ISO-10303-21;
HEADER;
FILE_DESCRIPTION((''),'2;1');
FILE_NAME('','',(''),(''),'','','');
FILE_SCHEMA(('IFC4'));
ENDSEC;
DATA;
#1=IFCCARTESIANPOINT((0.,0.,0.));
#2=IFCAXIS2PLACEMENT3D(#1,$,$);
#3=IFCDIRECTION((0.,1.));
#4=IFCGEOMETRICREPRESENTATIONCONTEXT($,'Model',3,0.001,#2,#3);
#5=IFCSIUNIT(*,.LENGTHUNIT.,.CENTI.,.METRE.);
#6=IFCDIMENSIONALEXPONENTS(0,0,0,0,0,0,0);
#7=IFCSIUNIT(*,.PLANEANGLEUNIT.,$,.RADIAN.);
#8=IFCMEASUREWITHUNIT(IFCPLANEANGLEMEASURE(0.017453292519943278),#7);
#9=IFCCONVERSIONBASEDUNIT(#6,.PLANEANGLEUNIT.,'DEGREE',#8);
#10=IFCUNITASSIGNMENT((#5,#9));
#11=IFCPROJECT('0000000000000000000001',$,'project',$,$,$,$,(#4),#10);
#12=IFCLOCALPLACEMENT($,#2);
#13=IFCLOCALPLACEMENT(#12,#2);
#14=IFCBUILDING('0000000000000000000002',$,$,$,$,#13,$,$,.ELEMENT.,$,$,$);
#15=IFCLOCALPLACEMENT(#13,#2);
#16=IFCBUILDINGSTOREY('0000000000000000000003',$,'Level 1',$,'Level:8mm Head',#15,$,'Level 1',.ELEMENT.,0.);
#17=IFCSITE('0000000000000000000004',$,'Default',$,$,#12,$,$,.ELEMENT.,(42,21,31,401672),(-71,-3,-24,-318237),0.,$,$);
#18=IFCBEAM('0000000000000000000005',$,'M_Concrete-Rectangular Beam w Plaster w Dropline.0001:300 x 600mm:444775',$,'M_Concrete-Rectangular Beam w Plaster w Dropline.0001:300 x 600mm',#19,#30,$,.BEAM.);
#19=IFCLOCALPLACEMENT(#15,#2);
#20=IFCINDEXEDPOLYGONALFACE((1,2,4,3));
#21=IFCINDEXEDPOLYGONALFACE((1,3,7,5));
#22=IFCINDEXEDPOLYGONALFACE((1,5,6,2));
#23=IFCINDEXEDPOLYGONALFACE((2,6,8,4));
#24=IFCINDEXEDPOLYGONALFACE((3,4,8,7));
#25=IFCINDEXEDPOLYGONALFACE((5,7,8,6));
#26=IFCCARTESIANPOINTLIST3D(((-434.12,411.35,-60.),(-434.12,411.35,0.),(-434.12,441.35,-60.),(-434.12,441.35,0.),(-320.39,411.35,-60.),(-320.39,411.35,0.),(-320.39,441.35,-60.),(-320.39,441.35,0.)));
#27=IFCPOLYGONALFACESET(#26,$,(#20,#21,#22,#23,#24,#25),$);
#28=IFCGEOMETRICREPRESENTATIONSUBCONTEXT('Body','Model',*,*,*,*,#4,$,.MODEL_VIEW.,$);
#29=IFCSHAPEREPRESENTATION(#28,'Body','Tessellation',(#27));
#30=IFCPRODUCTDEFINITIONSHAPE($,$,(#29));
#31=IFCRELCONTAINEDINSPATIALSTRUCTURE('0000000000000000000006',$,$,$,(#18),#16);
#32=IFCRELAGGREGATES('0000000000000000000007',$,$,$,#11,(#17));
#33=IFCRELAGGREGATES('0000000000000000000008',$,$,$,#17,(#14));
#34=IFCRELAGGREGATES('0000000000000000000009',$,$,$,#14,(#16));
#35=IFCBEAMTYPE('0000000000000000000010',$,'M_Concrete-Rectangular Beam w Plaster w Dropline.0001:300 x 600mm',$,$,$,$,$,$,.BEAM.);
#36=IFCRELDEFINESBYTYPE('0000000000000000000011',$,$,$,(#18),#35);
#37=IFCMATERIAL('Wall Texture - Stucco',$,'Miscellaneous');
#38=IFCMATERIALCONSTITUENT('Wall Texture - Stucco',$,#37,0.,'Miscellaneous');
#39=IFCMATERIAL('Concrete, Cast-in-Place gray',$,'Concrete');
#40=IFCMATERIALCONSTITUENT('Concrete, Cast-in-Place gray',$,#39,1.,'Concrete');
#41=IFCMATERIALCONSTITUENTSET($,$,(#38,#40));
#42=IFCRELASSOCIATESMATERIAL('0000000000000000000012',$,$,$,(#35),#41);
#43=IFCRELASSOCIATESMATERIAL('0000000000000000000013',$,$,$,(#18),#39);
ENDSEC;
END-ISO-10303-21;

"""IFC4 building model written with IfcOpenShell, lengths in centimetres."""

from ifc_helpers import new_model, entity, si_unit, converted_unit, direction, frame, origin, place, context, subcontext, project, spatial, indexed_curve, outline, extrude, source, transform, mapped, material, constituent, constituent_set, type_object, type_shapes, element, save


model = new_model("IFC4")

# Units and contexts
model_context = context("Model", 3, precision=0.001, world=origin(), true_north=direction((0.0, 1.0)))
body_context = subcontext(model_context, "Body", "Model", "MODEL_VIEW")
ifc_project = project(units=[si_unit("LENGTHUNIT", "METRE", prefix="CENTI"), converted_unit("PLANEANGLEUNIT", "DEGREE", entity("IfcPlaneAngleMeasure", 0.017453292519943278), si_unit("PLANEANGLEUNIT", "RADIAN"), dimensions=[0, 0, 0, 0, 0, 0, 0])], contexts=[model_context])

# Site, building, storey
site_placement = place(None, origin())
site = spatial("IfcSite", under=ifc_project, at=site_placement, Name="Default", CompositionType="ELEMENT", RefLatitude=(42, 21, 31, 401672), RefLongitude=(-71, -3, -24, -318237), RefElevation=0.0)
building_placement = place(site_placement, origin())
building = spatial("IfcBuilding", under=site, at=building_placement, CompositionType="ELEMENT")
storey_placement = place(building_placement, origin())
storey = spatial("IfcBuildingStorey", under=building, at=storey_placement, Name="Level 1", ObjectType="Level:8mm Head", LongName="Level 1", CompositionType="ELEMENT", Elevation=0.0)

# Beam
ifc_material_1 = material(Name="Concrete, Cast-in-Place gray", Category="Concrete")
ifc_material_2 = material(Name="Wall Texture - Stucco", Category="Miscellaneous")
ifc_constituent_1 = constituent(ifc_material_2, Name="Wall Texture - Stucco", Category="Miscellaneous", fraction=0.0)
ifc_constituent_2 = constituent(ifc_material_1, Name="Concrete, Cast-in-Place gray", Category="Concrete", fraction=1.0)
ifc_constituent_set_1 = constituent_set(constituents=[ifc_constituent_1, ifc_constituent_2])
beam_type_1 = type_object("IfcBeamType", Name="M_Concrete-Rectangular Beam w Plaster w Dropline.0001:300 x 600mm", PredefinedType="BEAM", material=ifc_constituent_set_1)
shared_shape_1 = source(origin(), body_context, "Body", "SweptSolid", [
    extrude(outline(indexed_curve([(-30.0, -15.0), (30.0, -15.0), (30.0, 15.0), (-30.0, 15.0), (-30.0, -15.0)], self_intersect=False)), frame((-434.12, 426.35, -30.0), z_axis=(1.0, 0.0, 0.0), x_axis=(0.0, 0.0, -1.0)), (0.0, 0.0, 1.0), 113.73),
])
type_shapes(beam_type_1, [shared_shape_1])
beam_1_placement = place(storey_placement, origin())
element("IfcBeam", 1, at=beam_1_placement, inside=storey, type_object=beam_type_1, material=ifc_material_1, Name="M_Concrete-Rectangular Beam w Plaster w Dropline.0001:300 x 600mm:444775", ObjectType="M_Concrete-Rectangular Beam w Plaster w Dropline.0001:300 x 600mm", PredefinedType="BEAM", context=body_context, shape_type="MappedRepresentation", body=[
    mapped(shared_shape_1, transform((0.0, 0.0, 0.0), scale=1.0)),
])

save(model, "model.ifc")
